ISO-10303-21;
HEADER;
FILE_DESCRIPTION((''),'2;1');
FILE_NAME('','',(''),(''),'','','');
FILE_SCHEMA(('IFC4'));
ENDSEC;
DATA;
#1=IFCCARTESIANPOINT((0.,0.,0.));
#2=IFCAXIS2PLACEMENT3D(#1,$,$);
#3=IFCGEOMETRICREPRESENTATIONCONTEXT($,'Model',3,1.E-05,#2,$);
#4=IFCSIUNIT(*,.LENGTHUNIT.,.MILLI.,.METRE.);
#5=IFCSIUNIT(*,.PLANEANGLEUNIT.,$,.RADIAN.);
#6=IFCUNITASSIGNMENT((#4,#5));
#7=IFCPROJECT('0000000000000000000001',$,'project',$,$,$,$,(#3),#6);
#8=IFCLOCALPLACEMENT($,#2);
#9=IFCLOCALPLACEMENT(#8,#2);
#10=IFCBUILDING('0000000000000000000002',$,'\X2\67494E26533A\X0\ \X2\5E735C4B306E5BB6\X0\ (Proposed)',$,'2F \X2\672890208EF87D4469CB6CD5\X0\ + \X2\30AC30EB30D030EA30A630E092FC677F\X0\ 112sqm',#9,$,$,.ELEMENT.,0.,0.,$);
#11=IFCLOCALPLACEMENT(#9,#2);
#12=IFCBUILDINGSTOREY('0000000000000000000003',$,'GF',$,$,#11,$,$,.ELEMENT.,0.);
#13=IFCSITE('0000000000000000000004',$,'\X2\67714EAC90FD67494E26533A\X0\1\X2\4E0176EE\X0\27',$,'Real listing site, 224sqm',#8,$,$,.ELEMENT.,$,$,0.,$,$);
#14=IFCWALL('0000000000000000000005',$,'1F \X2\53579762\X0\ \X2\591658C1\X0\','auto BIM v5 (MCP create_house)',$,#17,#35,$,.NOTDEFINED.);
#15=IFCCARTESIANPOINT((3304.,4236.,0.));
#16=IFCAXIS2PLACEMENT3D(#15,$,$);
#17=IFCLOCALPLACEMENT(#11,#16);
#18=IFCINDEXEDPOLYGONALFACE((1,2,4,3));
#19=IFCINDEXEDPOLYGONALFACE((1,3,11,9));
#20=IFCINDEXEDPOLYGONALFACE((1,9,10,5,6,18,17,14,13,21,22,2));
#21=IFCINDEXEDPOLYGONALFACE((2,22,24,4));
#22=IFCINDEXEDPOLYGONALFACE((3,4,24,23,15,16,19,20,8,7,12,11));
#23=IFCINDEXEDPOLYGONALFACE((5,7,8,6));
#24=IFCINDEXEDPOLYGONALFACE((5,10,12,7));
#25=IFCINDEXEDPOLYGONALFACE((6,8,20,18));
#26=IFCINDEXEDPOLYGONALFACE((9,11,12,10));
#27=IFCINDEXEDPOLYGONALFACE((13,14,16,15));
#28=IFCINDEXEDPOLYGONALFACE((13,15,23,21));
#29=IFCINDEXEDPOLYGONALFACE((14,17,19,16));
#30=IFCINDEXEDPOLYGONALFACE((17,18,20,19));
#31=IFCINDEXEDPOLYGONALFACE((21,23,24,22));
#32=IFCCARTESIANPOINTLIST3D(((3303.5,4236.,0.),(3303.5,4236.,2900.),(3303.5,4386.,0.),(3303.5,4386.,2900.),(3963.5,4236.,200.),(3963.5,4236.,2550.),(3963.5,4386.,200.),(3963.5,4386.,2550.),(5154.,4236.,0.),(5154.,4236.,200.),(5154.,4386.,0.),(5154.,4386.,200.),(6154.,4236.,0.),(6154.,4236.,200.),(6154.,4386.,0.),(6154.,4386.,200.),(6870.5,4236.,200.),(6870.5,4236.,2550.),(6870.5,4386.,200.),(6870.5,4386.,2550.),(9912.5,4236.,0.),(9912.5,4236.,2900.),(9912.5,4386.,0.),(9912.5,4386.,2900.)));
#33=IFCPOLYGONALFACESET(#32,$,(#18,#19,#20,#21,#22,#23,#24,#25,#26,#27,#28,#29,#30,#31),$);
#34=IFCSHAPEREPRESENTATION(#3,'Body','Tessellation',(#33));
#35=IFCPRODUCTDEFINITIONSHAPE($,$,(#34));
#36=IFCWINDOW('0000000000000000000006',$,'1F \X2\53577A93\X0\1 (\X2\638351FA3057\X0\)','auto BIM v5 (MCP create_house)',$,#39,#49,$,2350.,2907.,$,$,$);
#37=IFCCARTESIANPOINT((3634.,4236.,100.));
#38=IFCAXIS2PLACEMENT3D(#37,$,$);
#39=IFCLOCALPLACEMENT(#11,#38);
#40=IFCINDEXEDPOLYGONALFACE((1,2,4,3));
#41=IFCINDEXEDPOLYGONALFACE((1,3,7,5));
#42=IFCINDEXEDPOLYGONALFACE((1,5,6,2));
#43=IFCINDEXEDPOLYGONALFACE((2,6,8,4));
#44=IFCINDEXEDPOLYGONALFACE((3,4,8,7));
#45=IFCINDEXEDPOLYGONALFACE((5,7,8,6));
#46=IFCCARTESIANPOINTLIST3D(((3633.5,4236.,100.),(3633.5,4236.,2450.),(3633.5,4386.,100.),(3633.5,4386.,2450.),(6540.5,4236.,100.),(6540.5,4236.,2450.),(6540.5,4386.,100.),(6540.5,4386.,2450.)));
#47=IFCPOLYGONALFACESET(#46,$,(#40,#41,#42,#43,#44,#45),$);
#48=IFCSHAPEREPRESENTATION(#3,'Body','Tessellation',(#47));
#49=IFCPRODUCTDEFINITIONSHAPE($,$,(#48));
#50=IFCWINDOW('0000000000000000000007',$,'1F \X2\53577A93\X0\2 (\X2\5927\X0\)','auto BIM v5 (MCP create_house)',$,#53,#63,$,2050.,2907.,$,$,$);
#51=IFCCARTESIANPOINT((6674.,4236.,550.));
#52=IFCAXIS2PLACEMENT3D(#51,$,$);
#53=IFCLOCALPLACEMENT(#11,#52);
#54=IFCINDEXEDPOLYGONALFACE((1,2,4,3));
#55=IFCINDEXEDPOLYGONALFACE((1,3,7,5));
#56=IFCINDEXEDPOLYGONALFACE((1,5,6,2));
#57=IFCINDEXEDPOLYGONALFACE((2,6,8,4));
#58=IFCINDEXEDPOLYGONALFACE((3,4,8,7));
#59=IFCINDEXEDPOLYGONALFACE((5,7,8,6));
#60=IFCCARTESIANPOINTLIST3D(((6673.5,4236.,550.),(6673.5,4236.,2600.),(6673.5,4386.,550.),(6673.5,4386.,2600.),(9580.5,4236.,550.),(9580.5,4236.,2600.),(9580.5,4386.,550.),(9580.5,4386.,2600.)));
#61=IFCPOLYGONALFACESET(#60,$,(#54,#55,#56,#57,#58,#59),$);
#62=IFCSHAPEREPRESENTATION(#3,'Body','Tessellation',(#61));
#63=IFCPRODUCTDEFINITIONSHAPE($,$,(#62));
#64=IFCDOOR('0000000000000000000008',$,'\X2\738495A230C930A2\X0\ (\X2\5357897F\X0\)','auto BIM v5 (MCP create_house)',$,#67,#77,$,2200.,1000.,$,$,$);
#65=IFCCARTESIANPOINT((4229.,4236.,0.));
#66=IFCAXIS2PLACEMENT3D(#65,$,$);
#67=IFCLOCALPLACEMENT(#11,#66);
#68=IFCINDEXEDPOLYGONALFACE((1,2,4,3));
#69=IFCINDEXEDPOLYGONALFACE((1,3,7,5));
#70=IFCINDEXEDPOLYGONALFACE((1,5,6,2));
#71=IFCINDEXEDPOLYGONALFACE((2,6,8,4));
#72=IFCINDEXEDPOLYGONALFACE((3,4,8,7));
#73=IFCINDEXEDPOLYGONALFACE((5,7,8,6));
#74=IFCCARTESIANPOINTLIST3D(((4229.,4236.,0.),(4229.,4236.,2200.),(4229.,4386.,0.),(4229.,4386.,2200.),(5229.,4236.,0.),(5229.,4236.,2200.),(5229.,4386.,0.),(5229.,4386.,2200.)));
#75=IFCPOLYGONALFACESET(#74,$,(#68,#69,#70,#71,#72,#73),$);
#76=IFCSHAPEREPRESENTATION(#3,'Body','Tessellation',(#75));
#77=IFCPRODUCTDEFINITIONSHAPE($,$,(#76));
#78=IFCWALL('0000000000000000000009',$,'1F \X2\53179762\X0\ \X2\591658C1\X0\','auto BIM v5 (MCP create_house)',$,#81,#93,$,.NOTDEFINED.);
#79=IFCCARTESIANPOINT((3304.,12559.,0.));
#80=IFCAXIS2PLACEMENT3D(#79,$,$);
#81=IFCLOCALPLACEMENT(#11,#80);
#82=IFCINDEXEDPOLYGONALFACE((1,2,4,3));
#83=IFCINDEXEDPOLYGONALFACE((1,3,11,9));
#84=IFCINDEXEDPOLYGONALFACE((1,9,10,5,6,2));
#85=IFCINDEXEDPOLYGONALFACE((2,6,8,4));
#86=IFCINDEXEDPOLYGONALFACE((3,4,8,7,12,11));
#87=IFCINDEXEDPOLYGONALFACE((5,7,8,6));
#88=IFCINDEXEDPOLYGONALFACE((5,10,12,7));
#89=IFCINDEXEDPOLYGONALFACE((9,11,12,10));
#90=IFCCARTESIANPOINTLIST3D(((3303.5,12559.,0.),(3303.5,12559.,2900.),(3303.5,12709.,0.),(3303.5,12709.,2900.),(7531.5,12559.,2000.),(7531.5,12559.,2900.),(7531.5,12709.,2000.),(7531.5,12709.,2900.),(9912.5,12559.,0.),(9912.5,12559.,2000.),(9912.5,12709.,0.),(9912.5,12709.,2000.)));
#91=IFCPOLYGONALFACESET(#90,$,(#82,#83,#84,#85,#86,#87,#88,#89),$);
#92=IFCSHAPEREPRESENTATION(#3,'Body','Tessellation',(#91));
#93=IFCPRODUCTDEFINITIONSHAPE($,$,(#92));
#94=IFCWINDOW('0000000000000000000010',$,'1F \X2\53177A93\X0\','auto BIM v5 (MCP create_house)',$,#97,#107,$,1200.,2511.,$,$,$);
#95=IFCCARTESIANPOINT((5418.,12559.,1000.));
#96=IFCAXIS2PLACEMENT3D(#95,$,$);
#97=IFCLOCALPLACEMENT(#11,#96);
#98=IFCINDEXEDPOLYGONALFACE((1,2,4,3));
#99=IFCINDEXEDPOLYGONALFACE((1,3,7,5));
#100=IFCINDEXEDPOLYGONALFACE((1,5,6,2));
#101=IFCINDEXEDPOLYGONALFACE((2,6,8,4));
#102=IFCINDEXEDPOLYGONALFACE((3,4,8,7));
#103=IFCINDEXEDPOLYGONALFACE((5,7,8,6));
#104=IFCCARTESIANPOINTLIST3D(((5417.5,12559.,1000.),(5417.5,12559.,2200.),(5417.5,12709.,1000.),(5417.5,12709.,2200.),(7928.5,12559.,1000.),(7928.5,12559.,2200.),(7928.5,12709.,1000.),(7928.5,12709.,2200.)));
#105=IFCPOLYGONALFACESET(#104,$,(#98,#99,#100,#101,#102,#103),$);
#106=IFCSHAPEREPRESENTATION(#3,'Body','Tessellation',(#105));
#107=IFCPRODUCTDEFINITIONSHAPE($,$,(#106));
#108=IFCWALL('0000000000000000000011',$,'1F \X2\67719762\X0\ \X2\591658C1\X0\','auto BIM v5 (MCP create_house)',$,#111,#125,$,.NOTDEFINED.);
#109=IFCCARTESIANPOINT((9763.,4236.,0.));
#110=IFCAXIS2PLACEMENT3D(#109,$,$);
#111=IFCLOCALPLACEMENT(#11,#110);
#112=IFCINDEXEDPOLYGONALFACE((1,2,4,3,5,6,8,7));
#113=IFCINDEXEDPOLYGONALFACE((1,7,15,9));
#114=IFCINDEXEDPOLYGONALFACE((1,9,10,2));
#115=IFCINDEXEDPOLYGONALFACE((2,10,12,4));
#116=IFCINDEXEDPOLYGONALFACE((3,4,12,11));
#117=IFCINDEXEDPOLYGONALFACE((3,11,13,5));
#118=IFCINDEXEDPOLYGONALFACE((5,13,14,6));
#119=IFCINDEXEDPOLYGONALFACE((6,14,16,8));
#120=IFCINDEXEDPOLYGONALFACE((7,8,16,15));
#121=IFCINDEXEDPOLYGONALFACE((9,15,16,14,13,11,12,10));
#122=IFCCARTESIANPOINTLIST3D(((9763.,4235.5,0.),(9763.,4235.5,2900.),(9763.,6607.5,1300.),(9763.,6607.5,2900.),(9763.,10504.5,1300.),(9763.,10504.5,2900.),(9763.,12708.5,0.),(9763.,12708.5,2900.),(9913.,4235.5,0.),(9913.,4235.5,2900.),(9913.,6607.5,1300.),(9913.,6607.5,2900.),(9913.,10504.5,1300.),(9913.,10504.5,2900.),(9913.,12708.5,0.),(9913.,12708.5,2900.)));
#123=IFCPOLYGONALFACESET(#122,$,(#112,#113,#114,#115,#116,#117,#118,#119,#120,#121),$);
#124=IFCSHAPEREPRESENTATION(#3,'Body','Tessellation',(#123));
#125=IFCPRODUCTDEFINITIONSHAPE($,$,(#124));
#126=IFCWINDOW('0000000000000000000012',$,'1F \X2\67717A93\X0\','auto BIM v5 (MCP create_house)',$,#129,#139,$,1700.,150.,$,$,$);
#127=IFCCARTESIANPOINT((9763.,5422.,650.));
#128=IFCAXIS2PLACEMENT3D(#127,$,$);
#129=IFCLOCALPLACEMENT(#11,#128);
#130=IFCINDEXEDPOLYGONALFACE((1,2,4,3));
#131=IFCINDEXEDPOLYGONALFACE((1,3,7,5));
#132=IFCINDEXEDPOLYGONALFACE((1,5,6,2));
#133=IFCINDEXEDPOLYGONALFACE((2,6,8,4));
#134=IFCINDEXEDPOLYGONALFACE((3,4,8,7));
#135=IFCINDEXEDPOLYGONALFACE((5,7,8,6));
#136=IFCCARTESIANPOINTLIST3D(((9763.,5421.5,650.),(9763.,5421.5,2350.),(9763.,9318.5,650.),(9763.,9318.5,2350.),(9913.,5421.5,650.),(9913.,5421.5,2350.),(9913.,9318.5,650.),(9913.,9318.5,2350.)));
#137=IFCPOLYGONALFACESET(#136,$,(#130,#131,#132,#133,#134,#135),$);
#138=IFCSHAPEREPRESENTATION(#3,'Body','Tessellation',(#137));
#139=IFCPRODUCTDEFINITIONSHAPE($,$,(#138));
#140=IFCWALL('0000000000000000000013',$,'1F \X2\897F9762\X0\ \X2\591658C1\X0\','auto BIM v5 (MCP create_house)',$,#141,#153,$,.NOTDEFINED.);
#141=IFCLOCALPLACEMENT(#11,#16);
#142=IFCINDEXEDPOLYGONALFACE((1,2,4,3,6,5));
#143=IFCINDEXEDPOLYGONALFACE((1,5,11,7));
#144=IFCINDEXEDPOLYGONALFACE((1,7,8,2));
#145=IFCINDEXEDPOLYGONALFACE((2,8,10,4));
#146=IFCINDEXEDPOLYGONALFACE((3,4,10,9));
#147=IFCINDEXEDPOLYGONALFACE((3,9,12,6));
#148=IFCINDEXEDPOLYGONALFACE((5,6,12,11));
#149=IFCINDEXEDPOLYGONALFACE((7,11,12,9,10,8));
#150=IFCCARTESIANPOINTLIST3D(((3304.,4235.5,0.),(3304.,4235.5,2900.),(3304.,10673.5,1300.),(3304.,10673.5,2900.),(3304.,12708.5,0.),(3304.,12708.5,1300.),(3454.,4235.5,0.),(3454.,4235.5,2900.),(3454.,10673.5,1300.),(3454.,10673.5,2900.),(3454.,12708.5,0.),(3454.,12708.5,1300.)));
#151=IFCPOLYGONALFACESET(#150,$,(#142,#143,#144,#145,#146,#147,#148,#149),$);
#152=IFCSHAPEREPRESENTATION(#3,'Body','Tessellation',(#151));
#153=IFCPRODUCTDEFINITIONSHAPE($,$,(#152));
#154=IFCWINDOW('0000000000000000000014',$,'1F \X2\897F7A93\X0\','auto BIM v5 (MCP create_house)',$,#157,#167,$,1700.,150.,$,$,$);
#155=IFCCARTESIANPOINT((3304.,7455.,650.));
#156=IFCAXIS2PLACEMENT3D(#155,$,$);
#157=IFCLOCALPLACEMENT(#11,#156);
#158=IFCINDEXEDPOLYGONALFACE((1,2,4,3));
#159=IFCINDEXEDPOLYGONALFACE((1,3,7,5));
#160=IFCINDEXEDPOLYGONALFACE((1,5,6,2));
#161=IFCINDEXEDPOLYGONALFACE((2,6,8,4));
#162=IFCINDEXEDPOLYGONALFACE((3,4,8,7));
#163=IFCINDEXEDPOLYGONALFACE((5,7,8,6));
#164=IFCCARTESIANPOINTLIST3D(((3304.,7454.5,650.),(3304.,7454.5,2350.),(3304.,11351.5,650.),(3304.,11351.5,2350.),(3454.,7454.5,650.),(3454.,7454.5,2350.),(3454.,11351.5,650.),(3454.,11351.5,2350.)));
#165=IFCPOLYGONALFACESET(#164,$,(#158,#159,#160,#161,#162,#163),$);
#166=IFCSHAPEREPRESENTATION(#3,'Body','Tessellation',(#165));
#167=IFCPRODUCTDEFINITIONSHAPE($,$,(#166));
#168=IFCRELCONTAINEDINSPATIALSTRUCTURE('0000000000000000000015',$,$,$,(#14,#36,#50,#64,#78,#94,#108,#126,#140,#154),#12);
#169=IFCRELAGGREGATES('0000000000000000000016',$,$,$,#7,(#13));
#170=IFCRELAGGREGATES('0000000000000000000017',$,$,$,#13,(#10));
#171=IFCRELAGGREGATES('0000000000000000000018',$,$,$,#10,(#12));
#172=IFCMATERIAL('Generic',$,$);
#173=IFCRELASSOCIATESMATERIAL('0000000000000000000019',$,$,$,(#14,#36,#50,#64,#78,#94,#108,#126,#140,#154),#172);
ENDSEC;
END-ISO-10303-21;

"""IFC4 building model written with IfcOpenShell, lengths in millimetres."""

from ifc_helpers import new_model, si_unit, frame, frame_2d, origin, place, context, project, spatial, rectangle, extrude, material, element, fill, save


model = new_model("IFC4")

# Units and contexts
model_context = context("Model", 3, precision=1e-05, world=origin())
ifc_project = project(units=[si_unit("LENGTHUNIT", "METRE", prefix="MILLI"), si_unit("PLANEANGLEUNIT", "RADIAN")], contexts=[model_context])

# Site, building, storey
site_placement = place(None, origin())
site = spatial("IfcSite", under=ifc_project, at=site_placement, Name="東京都杉並区1丁目27", ObjectType="Real listing site, 224sqm", CompositionType="ELEMENT", RefElevation=0.0)
building_placement = place(site_placement, origin())
building = spatial("IfcBuilding", under=site, at=building_placement, Name="杉並区 平屋の家 (Proposed)", ObjectType="2F 木造軸組構法 + ガルバリウム鋼板 112sqm", CompositionType="ELEMENT", ElevationOfRefHeight=0.0, ElevationOfTerrain=0.0)
storey_placement = place(building_placement, origin())
storey = spatial("IfcBuildingStorey", under=building, at=storey_placement, Name="GF", CompositionType="ELEMENT", Elevation=0.0)

# Shared definitions
ifc_material = material(Name="Generic")

# Wall, openings, windows, door
wall_1_placement = place(storey_placement, frame((3304.0, 4236.0, 0.0)))
wall_1 = element("IfcWall", 1, at=wall_1_placement, inside=storey, material=ifc_material, Name="1F 南面 外壁", Description="auto BIM v5 (MCP create_house)", PredefinedType="NOTDEFINED", context=model_context, shape_type="SweptSolid", body=[
    extrude(rectangle(XDim=6609.0, YDim=150.0, at=frame_2d((3304.0, 75.0))), frame((3304.0, 4236.0, 0.0)), (0.0, 0.0, 1.0), 2900.0),
])
opening_1_placement = place(storey_placement, frame((3634.0, 4236.0, 100.0)))
opening_1 = element("IfcOpeningElement", 2, at=opening_1_placement, cuts=wall_1, PredefinedType="NOTDEFINED", context=model_context, shape_type="SweptSolid", body=[
    extrude(rectangle(XDim=2907.0, YDim=150.0, at=frame_2d((1453.0, 75.0))), frame((3634.0, 4236.0, 100.0)), (0.0, 0.0, 1.0), 2350.0),
])
opening_2_placement = place(storey_placement, frame((6674.0, 4236.0, 550.0)))
opening_2 = element("IfcOpeningElement", 3, at=opening_2_placement, cuts=wall_1, PredefinedType="NOTDEFINED", context=model_context, shape_type="SweptSolid", body=[
    extrude(rectangle(XDim=2907.0, YDim=150.0, at=frame_2d((1453.0, 75.0))), frame((6674.0, 4236.0, 550.0)), (0.0, 0.0, 1.0), 2050.0),
])
opening_3_placement = place(storey_placement, frame((4229.0, 4236.0, 0.0)))
opening_3 = element("IfcOpeningElement", 4, at=opening_3_placement, cuts=wall_1, PredefinedType="NOTDEFINED", context=model_context, shape_type="SweptSolid", body=[
    extrude(rectangle(XDim=1000.0, YDim=150.0, at=frame_2d((500.0, 75.0))), frame((4229.0, 4236.0, 0.0)), (0.0, 0.0, 1.0), 2200.0),
])
window_1_placement = place(storey_placement, frame((3634.0, 4236.0, 100.0)))
window_1 = element("IfcWindow", 5, at=window_1_placement, inside=storey, material=ifc_material, Name="1F 南窓1 (掃出し)", Description="auto BIM v5 (MCP create_house)", OverallHeight=2350.0, OverallWidth=2907.0, context=model_context, shape_type="SweptSolid", body=[
    extrude(rectangle(XDim=2907.0, YDim=150.0, at=frame_2d((1453.0, 75.0))), frame((3634.0, 4236.0, 100.0)), (0.0, 0.0, 1.0), 2350.0),
])
fill(opening_1, window_1)
window_2_placement = place(storey_placement, frame((6674.0, 4236.0, 550.0)))
window_2 = element("IfcWindow", 6, at=window_2_placement, inside=storey, material=ifc_material, Name="1F 南窓2 (大)", Description="auto BIM v5 (MCP create_house)", OverallHeight=2050.0, OverallWidth=2907.0, context=model_context, shape_type="SweptSolid", body=[
    extrude(rectangle(XDim=2907.0, YDim=150.0, at=frame_2d((1453.0, 75.0))), frame((6674.0, 4236.0, 550.0)), (0.0, 0.0, 1.0), 2050.0),
])
fill(opening_2, window_2)
door_1_placement = place(storey_placement, frame((4229.0, 4236.0, 0.0)))
door_1 = element("IfcDoor", 7, at=door_1_placement, inside=storey, material=ifc_material, Name="玄関ドア (南西)", Description="auto BIM v5 (MCP create_house)", OverallHeight=2200.0, OverallWidth=1000.0, context=model_context, shape_type="SweptSolid", body=[
    extrude(rectangle(XDim=1000.0, YDim=150.0, at=frame_2d((500.0, 75.0))), frame((4229.0, 4236.0, 0.0)), (0.0, 0.0, 1.0), 2200.0),
])
fill(opening_3, door_1)

# Walls, openings, windows
wall_2_placement = place(storey_placement, frame((3304.0, 12559.0, 0.0)))
wall_2 = element("IfcWall", 8, at=wall_2_placement, inside=storey, material=ifc_material, Name="1F 北面 外壁", Description="auto BIM v5 (MCP create_house)", PredefinedType="NOTDEFINED", context=model_context, shape_type="SweptSolid", body=[
    extrude(rectangle(XDim=6609.0, YDim=150.0, at=frame_2d((3304.0, 75.0))), frame((3304.0, 12559.0, 0.0)), (0.0, 0.0, 1.0), 2900.0),
])
opening_4_placement = place(storey_placement, frame((5418.0, 12559.0, 1000.0)))
opening_4 = element("IfcOpeningElement", 9, at=opening_4_placement, cuts=wall_2, PredefinedType="NOTDEFINED", context=model_context, shape_type="SweptSolid", body=[
    extrude(rectangle(XDim=2511.0, YDim=150.0, at=frame_2d((1255.0, 75.0))), frame((5418.0, 12559.0, 1000.0)), (0.0, 0.0, 1.0), 1200.0),
])
window_3_placement = place(storey_placement, frame((5418.0, 12559.0, 1000.0)))
window_3 = element("IfcWindow", 10, at=window_3_placement, inside=storey, material=ifc_material, Name="1F 北窓", Description="auto BIM v5 (MCP create_house)", OverallHeight=1200.0, OverallWidth=2511.0, context=model_context, shape_type="SweptSolid", body=[
    extrude(rectangle(XDim=2511.0, YDim=150.0, at=frame_2d((1255.0, 75.0))), frame((5418.0, 12559.0, 1000.0)), (0.0, 0.0, 1.0), 1200.0),
])
fill(opening_4, window_3)
wall_3_placement = place(storey_placement, frame((9763.0, 4236.0, 0.0)))
wall_3 = element("IfcWall", 11, at=wall_3_placement, inside=storey, material=ifc_material, Name="1F 東面 外壁", Description="auto BIM v5 (MCP create_house)", PredefinedType="NOTDEFINED", context=model_context, shape_type="SweptSolid", body=[
    extrude(rectangle(XDim=150.0, YDim=8473.0, at=frame_2d((75.0, 4236.0))), frame((9763.0, 4236.0, 0.0)), (0.0, 0.0, 1.0), 2900.0),
])
opening_5_placement = place(storey_placement, frame((9763.0, 5422.0, 650.0)))
opening_5 = element("IfcOpeningElement", 12, at=opening_5_placement, cuts=wall_3, PredefinedType="NOTDEFINED", context=model_context, shape_type="SweptSolid", body=[
    extrude(rectangle(XDim=150.0, YDim=3897.0, at=frame_2d((75.0, 1948.0))), frame((9763.0, 5422.0, 650.0)), (0.0, 0.0, 1.0), 1700.0),
])
window_4_placement = place(storey_placement, frame((9763.0, 5422.0, 650.0)))
window_4 = element("IfcWindow", 13, at=window_4_placement, inside=storey, material=ifc_material, Name="1F 東窓", Description="auto BIM v5 (MCP create_house)", OverallHeight=1700.0, OverallWidth=150.0, context=model_context, shape_type="SweptSolid", body=[
    extrude(rectangle(XDim=150.0, YDim=3897.0, at=frame_2d((75.0, 1948.0))), frame((9763.0, 5422.0, 650.0)), (0.0, 0.0, 1.0), 1700.0),
])
fill(opening_5, window_4)
wall_4_placement = place(storey_placement, frame((3304.0, 4236.0, 0.0)))
wall_4 = element("IfcWall", 14, at=wall_4_placement, inside=storey, material=ifc_material, Name="1F 西面 外壁", Description="auto BIM v5 (MCP create_house)", PredefinedType="NOTDEFINED", context=model_context, shape_type="SweptSolid", body=[
    extrude(rectangle(XDim=150.0, YDim=8473.0, at=frame_2d((75.0, 4236.0))), frame((3304.0, 4236.0, 0.0)), (0.0, 0.0, 1.0), 2900.0),
])
opening_6_placement = place(storey_placement, frame((3304.0, 7455.0, 650.0)))
opening_6 = element("IfcOpeningElement", 15, at=opening_6_placement, cuts=wall_4, PredefinedType="NOTDEFINED", context=model_context, shape_type="SweptSolid", body=[
    extrude(rectangle(XDim=150.0, YDim=3897.0, at=frame_2d((75.0, 1948.0))), frame((3304.0, 7455.0, 650.0)), (0.0, 0.0, 1.0), 1700.0),
])
window_5_placement = place(storey_placement, frame((3304.0, 7455.0, 650.0)))
window_5 = element("IfcWindow", 16, at=window_5_placement, inside=storey, material=ifc_material, Name="1F 西窓", Description="auto BIM v5 (MCP create_house)", OverallHeight=1700.0, OverallWidth=150.0, context=model_context, shape_type="SweptSolid", body=[
    extrude(rectangle(XDim=150.0, YDim=3897.0, at=frame_2d((75.0, 1948.0))), frame((3304.0, 7455.0, 650.0)), (0.0, 0.0, 1.0), 1700.0),
])
fill(opening_6, window_5)

save(model, "model.ifc")
